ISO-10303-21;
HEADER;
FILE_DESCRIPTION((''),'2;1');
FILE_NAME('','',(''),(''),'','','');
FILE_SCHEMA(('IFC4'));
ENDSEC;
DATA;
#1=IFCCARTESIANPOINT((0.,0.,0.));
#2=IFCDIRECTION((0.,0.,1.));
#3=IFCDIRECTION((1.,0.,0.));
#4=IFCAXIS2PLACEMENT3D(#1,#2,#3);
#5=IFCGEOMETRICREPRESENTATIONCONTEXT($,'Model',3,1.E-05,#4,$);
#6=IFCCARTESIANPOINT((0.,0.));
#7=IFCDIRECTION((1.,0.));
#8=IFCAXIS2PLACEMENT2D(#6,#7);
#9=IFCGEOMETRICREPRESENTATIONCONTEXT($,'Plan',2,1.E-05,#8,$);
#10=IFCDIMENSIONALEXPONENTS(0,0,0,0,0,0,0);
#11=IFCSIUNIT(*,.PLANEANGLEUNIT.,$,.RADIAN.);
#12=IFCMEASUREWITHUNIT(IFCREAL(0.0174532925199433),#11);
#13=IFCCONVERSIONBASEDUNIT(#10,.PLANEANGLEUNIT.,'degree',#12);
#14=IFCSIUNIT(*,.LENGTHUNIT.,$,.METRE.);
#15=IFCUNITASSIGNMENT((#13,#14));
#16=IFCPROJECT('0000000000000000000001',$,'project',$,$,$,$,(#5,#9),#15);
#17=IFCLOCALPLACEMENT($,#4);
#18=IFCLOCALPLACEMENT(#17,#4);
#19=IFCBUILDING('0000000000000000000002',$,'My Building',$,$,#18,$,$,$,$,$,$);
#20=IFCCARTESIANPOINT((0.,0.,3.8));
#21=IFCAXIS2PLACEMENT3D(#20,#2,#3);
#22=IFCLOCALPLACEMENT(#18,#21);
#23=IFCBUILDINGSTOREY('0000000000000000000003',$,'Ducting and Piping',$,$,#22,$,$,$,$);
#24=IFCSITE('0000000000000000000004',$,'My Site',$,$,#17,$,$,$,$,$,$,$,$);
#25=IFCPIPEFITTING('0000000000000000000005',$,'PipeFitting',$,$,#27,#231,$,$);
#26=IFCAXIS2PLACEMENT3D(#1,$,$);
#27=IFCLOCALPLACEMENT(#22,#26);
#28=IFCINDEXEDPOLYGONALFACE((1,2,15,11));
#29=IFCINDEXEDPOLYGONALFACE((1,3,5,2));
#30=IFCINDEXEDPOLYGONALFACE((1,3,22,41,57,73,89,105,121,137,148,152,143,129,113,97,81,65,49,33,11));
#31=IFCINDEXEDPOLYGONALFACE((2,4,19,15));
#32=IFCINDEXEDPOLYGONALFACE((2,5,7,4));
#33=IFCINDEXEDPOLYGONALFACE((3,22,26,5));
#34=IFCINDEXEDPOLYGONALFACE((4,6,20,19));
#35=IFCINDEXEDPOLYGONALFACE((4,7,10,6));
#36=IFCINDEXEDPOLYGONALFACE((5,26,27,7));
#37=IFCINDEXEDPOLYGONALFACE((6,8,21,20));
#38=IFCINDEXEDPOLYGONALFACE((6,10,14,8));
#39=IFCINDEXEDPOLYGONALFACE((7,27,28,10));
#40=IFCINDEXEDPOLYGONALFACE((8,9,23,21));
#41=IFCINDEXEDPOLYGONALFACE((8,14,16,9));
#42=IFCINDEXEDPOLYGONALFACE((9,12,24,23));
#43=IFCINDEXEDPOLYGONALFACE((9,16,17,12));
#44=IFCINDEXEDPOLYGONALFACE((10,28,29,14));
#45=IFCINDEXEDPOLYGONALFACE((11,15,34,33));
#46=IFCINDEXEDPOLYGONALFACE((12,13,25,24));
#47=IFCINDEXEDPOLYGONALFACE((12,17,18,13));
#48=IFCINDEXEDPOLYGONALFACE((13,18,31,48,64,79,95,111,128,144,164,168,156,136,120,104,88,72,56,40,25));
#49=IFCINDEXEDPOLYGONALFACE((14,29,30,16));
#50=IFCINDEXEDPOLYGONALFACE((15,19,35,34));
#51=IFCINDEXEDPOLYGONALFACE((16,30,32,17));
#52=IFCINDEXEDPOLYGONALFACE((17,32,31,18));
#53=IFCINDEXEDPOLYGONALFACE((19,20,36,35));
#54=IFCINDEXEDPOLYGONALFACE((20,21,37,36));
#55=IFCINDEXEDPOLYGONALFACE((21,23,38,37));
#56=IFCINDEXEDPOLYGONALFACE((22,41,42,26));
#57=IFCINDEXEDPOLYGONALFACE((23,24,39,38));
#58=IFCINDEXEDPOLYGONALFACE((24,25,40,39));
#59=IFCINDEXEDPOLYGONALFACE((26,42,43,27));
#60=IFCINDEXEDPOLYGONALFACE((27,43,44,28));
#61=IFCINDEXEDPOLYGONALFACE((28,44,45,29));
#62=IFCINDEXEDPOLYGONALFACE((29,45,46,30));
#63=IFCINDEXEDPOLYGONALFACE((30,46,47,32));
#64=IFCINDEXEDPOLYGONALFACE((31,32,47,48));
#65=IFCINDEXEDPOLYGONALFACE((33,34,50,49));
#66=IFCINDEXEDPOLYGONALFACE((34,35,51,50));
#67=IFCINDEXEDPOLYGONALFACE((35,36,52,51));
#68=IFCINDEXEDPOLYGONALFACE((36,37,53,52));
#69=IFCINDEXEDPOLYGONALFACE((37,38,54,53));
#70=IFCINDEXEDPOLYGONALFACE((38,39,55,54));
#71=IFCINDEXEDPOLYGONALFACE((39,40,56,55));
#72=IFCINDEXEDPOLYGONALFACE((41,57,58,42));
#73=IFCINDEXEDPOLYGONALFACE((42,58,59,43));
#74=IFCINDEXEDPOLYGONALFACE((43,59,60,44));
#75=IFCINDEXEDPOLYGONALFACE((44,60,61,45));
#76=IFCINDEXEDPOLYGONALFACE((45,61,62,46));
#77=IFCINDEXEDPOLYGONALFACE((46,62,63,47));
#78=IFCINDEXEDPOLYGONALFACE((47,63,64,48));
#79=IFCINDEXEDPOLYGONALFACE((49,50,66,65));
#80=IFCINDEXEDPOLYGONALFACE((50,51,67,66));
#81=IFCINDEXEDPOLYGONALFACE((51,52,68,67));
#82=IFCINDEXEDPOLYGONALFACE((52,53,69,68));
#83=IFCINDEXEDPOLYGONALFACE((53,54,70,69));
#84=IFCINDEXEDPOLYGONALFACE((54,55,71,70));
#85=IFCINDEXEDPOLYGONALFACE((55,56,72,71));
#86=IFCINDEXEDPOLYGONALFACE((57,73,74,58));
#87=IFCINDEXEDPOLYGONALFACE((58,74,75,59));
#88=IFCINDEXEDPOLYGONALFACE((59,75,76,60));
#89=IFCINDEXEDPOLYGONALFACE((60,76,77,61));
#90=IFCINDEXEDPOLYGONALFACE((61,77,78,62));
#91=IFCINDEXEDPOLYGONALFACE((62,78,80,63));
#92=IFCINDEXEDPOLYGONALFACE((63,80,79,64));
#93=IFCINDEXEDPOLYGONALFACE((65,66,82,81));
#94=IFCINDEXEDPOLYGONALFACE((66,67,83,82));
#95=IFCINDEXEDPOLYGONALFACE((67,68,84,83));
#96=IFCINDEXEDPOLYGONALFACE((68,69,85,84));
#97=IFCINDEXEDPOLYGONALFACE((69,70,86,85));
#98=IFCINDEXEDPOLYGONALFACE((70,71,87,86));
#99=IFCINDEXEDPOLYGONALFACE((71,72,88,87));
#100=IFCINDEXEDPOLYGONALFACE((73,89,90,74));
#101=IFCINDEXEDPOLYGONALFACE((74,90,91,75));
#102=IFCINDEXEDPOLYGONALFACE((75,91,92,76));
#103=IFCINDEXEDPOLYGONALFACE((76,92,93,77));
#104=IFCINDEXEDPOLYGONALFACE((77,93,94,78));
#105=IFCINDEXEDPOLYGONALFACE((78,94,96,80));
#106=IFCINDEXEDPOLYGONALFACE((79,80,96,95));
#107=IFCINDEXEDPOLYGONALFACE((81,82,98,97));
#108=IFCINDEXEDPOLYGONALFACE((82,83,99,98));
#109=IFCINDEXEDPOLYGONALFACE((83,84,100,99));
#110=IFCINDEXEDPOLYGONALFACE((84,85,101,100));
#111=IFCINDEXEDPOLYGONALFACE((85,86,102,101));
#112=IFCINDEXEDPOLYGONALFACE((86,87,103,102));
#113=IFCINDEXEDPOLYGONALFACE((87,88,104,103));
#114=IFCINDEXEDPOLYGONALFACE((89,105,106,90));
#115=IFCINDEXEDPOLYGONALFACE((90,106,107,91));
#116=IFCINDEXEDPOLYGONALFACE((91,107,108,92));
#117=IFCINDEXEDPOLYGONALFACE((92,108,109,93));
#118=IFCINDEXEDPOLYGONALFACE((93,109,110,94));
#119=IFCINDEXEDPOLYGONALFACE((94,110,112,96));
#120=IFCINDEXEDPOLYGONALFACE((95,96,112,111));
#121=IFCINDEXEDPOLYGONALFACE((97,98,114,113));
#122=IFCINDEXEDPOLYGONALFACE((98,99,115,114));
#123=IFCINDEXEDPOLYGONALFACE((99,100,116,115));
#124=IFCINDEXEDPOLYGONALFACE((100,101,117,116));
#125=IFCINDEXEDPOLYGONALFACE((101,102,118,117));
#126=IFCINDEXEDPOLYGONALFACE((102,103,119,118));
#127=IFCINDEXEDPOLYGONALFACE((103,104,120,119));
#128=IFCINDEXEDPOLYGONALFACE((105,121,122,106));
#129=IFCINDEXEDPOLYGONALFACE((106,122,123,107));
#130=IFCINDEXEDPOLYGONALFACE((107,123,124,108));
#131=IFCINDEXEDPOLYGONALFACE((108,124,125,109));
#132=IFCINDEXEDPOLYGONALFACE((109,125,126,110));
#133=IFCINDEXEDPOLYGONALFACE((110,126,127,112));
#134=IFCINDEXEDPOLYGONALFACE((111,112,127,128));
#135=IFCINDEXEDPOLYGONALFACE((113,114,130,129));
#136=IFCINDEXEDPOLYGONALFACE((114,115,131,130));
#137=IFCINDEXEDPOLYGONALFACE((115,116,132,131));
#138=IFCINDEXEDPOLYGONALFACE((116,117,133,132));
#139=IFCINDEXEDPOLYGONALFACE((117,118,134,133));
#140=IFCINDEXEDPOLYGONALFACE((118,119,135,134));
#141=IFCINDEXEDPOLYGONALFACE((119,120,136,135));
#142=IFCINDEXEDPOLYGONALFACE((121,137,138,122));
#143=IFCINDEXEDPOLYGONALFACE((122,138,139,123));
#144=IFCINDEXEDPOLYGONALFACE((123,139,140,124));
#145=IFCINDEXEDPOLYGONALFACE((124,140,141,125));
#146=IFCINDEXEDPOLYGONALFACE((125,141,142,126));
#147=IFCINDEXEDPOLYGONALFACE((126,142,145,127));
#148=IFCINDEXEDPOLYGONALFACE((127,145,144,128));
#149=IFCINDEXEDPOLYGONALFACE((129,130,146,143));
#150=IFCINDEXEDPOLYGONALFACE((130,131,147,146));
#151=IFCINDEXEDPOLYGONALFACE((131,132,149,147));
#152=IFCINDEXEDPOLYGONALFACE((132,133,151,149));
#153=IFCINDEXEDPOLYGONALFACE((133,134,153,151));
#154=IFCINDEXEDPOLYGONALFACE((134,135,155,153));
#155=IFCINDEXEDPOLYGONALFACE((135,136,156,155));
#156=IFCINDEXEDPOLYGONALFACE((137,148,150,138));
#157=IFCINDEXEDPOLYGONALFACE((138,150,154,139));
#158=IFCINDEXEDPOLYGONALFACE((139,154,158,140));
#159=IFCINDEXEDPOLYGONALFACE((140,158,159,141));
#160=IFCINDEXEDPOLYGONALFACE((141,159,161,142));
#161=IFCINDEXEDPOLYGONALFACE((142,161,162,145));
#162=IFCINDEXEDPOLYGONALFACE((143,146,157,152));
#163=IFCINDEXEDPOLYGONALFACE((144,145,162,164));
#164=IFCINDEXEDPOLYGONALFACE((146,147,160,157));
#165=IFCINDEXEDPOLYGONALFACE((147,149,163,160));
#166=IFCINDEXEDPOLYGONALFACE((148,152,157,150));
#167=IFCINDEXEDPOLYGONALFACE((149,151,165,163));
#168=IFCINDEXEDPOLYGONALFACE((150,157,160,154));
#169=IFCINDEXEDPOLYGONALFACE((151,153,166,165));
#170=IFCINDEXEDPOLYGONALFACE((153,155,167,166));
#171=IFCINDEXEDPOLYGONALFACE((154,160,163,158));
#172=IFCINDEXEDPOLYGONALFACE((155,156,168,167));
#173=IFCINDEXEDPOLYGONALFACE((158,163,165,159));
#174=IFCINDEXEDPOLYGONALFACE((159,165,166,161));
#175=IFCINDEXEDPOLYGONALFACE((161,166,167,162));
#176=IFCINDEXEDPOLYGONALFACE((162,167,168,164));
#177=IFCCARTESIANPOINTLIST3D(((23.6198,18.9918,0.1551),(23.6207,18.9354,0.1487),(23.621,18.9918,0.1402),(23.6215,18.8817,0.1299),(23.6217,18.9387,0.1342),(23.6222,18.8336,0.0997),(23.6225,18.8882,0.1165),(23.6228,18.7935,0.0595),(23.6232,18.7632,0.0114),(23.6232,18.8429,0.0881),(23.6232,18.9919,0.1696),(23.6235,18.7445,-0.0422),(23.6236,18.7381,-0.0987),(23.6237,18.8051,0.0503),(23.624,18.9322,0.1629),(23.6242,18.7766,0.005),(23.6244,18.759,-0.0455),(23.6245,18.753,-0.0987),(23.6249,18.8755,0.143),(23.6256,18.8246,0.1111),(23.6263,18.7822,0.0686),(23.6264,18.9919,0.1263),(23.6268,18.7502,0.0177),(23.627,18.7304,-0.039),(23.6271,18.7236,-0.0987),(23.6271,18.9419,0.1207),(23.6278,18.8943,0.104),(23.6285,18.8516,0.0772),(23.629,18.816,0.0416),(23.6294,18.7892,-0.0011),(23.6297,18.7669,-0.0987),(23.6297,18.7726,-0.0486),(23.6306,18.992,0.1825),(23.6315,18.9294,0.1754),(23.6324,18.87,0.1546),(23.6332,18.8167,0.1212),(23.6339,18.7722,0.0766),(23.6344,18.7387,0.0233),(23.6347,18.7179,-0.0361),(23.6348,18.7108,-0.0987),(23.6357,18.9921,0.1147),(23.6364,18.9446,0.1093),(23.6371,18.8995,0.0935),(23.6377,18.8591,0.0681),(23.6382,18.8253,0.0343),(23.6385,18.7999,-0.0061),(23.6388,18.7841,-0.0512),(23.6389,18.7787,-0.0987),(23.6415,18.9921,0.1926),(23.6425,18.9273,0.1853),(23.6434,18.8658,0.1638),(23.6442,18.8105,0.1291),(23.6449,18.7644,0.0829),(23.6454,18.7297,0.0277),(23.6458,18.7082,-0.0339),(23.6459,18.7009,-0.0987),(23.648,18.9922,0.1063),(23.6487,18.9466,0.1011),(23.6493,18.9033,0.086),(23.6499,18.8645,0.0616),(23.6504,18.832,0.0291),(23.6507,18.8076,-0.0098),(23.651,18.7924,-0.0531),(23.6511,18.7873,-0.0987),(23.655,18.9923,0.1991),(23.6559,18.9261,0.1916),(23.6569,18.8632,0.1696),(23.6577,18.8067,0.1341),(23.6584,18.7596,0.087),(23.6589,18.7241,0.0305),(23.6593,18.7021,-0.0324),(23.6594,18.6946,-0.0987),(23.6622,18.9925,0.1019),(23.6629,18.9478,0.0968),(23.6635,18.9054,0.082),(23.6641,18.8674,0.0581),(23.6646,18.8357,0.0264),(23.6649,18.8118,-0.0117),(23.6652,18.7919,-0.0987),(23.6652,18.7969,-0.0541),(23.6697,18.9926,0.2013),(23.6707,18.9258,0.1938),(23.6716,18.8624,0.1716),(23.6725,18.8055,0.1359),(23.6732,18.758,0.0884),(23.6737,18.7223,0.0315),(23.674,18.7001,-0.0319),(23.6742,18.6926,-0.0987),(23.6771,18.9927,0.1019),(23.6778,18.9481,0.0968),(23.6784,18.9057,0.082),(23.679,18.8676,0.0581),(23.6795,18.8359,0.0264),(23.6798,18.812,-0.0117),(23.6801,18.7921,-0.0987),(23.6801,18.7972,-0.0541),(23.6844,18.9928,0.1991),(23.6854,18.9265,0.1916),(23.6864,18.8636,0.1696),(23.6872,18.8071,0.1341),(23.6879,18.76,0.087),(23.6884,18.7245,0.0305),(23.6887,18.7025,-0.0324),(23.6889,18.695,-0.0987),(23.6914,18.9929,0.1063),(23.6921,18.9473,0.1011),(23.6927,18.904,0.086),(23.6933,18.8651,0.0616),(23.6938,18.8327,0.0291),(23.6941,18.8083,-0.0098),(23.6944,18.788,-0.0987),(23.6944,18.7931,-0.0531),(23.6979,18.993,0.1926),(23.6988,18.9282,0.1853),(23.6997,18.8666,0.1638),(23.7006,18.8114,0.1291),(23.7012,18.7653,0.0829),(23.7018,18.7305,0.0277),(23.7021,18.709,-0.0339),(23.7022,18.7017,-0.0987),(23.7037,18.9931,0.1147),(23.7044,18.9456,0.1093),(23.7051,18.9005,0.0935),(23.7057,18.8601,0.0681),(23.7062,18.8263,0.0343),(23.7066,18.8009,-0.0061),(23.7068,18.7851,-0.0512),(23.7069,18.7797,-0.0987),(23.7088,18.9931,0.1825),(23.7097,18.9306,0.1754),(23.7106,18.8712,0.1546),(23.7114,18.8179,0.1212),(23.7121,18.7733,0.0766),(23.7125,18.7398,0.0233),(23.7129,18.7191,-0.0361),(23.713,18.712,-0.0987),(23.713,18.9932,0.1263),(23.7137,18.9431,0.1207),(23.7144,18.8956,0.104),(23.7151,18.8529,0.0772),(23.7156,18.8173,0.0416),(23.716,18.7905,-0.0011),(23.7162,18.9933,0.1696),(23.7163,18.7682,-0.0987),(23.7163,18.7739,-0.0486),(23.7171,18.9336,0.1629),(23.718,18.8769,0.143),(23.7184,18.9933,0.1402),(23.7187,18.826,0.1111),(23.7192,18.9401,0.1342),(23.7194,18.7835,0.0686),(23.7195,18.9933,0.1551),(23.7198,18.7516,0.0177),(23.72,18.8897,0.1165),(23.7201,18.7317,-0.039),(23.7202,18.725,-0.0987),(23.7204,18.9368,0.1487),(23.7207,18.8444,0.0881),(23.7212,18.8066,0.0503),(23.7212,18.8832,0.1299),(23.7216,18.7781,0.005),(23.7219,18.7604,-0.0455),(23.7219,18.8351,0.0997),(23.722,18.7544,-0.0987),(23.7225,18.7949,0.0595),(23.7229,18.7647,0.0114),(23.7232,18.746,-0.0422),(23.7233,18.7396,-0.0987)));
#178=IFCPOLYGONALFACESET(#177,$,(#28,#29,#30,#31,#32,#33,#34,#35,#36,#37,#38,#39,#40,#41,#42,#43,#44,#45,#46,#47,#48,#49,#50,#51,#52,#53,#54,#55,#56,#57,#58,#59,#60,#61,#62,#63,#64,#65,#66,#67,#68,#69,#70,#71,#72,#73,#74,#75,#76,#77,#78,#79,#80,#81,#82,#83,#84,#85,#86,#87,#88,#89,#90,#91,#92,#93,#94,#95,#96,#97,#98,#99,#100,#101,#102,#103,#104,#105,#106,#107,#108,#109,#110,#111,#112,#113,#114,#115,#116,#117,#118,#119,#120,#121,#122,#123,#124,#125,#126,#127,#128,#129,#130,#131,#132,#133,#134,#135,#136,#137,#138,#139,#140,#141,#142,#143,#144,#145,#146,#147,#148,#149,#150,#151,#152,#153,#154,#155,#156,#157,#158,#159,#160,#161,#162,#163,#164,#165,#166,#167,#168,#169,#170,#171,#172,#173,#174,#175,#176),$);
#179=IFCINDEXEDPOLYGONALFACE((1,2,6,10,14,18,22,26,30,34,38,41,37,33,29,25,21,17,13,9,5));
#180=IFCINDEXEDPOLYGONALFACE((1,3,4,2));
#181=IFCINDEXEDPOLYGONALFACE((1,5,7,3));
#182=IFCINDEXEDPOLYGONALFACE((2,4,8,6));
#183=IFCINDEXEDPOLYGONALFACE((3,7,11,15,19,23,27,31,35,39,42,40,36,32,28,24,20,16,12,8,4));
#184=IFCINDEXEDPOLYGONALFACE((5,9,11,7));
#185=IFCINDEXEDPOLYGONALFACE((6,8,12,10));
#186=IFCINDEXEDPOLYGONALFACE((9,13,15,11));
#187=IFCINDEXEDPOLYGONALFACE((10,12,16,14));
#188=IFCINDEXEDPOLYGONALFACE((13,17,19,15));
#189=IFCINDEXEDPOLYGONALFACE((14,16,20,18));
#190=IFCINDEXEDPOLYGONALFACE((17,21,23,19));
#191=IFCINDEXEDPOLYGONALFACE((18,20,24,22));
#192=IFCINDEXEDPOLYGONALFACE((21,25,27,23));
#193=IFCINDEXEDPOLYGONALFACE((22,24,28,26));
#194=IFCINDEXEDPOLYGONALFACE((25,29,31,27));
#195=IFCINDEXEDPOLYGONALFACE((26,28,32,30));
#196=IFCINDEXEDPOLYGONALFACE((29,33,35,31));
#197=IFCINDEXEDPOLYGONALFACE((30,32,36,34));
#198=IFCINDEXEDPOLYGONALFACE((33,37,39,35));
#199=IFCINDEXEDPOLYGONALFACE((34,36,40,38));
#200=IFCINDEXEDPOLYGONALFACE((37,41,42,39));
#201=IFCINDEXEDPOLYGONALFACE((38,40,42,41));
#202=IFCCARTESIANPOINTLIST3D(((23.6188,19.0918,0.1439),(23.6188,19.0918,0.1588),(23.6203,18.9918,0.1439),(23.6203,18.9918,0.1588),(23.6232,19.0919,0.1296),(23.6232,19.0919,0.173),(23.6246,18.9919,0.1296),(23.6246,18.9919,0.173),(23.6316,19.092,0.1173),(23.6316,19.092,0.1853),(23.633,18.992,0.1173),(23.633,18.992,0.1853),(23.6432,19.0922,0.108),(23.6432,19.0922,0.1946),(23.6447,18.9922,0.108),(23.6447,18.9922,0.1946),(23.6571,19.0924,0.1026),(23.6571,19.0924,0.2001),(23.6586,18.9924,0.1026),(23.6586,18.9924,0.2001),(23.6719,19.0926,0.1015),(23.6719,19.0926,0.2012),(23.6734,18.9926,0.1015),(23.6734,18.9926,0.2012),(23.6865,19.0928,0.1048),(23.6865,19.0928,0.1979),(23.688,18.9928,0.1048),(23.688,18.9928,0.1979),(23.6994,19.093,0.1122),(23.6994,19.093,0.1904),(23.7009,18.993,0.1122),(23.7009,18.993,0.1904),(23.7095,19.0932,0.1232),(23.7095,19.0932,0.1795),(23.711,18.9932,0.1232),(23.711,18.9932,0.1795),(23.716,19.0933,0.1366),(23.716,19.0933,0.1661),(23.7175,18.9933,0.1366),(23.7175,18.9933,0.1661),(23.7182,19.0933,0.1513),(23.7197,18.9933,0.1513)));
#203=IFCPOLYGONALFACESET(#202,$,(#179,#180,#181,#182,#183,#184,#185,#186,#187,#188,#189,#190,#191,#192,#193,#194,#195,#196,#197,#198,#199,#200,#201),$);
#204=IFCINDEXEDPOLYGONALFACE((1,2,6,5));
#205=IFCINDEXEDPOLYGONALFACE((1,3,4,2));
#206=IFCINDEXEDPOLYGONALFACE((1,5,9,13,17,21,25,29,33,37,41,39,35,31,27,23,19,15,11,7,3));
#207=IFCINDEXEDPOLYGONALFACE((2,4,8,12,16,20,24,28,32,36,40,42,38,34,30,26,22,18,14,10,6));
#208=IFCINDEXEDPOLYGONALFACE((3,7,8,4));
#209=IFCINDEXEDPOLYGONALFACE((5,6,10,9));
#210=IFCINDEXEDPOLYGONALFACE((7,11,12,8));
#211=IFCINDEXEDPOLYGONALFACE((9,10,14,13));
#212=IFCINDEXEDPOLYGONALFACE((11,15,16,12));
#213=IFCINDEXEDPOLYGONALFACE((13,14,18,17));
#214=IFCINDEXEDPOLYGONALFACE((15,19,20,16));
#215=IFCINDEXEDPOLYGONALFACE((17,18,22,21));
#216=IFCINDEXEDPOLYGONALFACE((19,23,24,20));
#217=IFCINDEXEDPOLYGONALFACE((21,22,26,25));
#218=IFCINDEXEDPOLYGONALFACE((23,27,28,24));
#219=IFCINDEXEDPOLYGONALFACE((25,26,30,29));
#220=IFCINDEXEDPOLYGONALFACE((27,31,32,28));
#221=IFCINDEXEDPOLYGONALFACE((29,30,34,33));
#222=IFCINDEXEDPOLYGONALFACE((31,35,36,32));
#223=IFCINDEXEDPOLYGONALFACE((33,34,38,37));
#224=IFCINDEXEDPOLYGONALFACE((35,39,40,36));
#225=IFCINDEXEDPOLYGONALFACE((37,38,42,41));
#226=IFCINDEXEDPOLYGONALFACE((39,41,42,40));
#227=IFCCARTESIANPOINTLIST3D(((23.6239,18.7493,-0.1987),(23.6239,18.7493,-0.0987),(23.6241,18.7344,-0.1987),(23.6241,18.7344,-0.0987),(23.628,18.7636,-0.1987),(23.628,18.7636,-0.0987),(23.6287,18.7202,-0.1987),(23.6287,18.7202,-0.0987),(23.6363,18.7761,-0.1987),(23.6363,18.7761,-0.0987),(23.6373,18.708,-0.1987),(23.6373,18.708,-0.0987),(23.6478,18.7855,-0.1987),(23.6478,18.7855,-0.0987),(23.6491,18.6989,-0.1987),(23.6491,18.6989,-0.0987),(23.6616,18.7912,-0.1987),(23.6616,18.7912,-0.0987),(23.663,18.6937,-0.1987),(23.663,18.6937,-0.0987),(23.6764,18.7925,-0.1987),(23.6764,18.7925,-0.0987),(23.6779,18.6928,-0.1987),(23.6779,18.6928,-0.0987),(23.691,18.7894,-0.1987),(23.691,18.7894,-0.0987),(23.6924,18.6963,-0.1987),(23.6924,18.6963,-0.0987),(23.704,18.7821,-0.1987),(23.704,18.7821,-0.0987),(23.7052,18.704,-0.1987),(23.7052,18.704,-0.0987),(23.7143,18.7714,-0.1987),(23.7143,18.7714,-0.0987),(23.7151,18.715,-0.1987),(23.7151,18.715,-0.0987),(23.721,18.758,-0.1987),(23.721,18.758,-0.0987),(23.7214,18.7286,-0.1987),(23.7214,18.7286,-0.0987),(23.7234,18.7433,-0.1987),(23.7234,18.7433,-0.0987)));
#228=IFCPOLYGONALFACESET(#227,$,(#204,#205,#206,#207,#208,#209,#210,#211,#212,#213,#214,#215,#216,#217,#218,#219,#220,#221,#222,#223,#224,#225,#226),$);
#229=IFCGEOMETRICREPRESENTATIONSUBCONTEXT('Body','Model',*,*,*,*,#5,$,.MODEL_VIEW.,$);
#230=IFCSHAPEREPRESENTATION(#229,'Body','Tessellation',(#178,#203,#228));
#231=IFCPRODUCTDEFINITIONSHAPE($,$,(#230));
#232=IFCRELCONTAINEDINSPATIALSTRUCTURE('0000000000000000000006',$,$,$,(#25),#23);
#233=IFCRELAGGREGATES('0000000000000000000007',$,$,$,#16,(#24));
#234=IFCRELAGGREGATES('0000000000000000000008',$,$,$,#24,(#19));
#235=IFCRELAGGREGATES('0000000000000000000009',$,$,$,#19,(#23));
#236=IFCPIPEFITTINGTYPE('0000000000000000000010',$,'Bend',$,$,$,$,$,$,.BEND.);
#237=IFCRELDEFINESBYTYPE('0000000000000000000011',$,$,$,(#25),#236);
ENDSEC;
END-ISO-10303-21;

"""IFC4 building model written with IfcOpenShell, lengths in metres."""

from ifc_helpers import new_model, entity, si_unit, converted_unit, frame, origin_with_axes, origin_2d_with_axis, place, context, subcontext, project, spatial, circle, extrude, source, transform, mapped, type_object, type_shapes, element, save


model = new_model("IFC4")

# Units and contexts
model_context = context("Model", 3, precision=1e-05, world=origin_with_axes())
plan_context = context("Plan", 2, precision=1e-05, world=origin_2d_with_axis())
body_context = subcontext(model_context, "Body", "Model", "MODEL_VIEW")
ifc_project = project(units=[converted_unit("PLANEANGLEUNIT", "degree", entity("IfcReal", 0.0174532925199433), si_unit("PLANEANGLEUNIT", "RADIAN"), dimensions=[0, 0, 0, 0, 0, 0, 0]), si_unit("LENGTHUNIT", "METRE")], contexts=[model_context, plan_context])

# Site, building, storey
site_placement = place(None, origin_with_axes())
site = spatial("IfcSite", under=ifc_project, at=site_placement, Name="My Site")
building_placement = place(site_placement, origin_with_axes())
building = spatial("IfcBuilding", under=site, at=building_placement, Name="My Building")
storey_placement = place(building_placement, frame((0.0, 0.0, 3.8), z_axis=(0.0, 0.0, 1.0), x_axis=(1.0, 0.0, 0.0)))
storey = spatial("IfcBuildingStorey", under=building, at=storey_placement, Name="Ducting and Piping")

# Pipe fitting
pipe_fitting_type = type_object("IfcPipeFittingType", Name="Bend", PredefinedType="BEND")
shared_shape = source(origin_with_axes(), body_context, "Body", "SolidModel", [
    entity("IfcSweptDiskSolid", entity("IfcIndexedPolyCurve", entity("IfcCartesianPointList3D", [[0.0, 0.0, 0.1], [0.0, -0.0732, 0.2768], [0.0, -0.25, 0.35]]), [entity("IfcArcIndex", [1, 2, 3])]), 0.05),
    extrude(circle(Radius=0.05), origin_with_axes(), (0.0, 0.0, 1.0), 0.1),
    extrude(circle(Radius=0.05), frame((0.0, -0.25, 0.35), z_axis=(0.0, -1.0, 0.0), x_axis=(1.0, 0.0, 0.0)), (0.0, 0.0, 1.0), 0.1),
])
type_shapes(pipe_fitting_type, [shared_shape])
for number, where, z_axis, x_axis, name in (
    (1, (23.6682, 19.0926, 0.1513), (0.014879, -0.999889, 0.0), (0.999889, 0.014879, 0.0), "PipeFitting"),
):
    element("IfcPipeFitting", number, at=place(storey_placement, frame(where, z_axis=z_axis, x_axis=x_axis)), inside=storey, type_object=pipe_fitting_type, Name=name, context=body_context, shape_type="MappedRepresentation", body=[
        mapped(shared_shape, transform((0.0, 0.0, 0.0), x_axis=(1.0, 0.0, 0.0), y_axis=(0.0, 1.0, 0.0), z_axis=(0.0, 0.0, 1.0), scale=1.0)),
    ])

save(model, "model.ifc")
